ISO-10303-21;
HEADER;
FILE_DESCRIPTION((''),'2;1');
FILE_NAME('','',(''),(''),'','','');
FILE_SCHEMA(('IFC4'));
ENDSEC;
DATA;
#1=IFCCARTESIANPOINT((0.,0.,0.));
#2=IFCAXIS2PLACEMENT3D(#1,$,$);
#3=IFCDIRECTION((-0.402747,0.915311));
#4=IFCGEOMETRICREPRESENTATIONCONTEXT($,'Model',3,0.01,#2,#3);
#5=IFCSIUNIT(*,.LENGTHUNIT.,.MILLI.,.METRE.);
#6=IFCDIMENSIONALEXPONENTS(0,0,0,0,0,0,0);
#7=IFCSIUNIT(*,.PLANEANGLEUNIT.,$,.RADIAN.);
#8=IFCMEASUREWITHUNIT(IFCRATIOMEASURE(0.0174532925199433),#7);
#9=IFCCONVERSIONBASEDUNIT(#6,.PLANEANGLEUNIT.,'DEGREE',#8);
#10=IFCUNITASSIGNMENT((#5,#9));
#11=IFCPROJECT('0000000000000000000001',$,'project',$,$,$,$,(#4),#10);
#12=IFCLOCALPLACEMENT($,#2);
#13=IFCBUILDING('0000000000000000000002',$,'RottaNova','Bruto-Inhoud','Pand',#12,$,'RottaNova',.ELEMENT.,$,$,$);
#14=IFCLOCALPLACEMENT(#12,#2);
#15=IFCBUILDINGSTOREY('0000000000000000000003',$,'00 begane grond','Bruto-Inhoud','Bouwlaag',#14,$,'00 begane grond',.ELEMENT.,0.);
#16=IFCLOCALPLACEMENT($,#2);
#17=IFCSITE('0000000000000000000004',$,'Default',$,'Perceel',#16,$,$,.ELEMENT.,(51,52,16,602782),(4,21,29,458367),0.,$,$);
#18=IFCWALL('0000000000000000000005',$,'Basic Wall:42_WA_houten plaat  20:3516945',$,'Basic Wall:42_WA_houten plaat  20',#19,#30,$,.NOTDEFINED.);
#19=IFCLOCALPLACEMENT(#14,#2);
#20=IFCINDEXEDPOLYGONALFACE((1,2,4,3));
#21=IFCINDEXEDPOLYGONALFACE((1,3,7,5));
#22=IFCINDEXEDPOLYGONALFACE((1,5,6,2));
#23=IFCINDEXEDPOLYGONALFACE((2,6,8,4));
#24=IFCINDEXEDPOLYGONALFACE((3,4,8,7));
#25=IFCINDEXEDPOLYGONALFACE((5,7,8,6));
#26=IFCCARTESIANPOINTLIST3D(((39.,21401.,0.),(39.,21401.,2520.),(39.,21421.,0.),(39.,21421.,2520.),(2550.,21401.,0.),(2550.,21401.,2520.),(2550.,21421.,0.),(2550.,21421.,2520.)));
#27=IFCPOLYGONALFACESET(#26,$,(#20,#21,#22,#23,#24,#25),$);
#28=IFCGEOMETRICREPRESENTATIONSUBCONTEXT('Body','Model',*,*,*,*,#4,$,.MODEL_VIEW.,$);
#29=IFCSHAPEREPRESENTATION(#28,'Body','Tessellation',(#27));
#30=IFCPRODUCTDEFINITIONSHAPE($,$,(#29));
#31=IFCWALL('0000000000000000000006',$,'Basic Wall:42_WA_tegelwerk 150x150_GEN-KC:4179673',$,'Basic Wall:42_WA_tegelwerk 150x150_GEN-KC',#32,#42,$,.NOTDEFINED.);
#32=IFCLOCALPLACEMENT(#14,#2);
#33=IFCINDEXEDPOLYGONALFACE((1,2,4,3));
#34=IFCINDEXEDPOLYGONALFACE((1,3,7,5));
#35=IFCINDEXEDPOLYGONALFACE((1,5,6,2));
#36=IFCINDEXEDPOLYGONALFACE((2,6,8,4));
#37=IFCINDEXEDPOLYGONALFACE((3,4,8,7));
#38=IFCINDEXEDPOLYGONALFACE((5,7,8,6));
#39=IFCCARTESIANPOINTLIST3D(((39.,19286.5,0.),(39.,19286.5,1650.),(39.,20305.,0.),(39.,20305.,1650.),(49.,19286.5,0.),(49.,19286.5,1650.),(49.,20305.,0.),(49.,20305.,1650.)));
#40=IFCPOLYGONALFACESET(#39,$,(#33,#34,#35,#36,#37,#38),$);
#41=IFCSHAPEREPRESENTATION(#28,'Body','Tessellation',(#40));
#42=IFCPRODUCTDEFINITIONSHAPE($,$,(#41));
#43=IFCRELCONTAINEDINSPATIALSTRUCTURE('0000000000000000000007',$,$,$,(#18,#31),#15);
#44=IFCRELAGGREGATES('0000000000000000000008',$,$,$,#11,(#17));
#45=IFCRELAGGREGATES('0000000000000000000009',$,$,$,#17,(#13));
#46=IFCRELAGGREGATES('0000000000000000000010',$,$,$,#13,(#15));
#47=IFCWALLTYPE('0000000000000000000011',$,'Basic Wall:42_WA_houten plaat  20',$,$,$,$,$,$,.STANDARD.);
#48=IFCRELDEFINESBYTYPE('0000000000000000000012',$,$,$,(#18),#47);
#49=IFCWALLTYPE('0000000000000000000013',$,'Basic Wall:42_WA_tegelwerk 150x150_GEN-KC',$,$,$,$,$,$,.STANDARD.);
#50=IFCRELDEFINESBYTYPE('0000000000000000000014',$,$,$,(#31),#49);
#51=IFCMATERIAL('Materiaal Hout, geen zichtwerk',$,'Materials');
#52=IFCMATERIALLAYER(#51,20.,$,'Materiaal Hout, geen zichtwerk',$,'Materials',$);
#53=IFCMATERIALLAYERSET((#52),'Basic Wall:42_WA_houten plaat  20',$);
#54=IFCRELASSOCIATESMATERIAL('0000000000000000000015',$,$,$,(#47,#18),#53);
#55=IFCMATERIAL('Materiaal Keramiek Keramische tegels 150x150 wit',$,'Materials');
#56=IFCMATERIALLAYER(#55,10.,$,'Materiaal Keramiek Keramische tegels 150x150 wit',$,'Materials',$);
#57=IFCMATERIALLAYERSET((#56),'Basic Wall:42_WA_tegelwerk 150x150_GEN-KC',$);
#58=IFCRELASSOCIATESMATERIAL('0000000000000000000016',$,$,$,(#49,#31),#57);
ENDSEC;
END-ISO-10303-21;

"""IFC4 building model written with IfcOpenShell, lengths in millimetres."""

from ifc_helpers import new_model, entity, si_unit, converted_unit, direction, frame, frame_2d, origin, place, context, subcontext, project, spatial, rectangle, extrude, material, layer, layer_set, type_object, element, save


model = new_model("IFC4")

# Units and contexts
model_context = context("Model", 3, precision=0.01, world=origin(), true_north=direction((-0.402747, 0.915311)))
body_context = subcontext(model_context, "Body", "Model", "MODEL_VIEW")
ifc_project = project(units=[si_unit("LENGTHUNIT", "METRE", prefix="MILLI"), converted_unit("PLANEANGLEUNIT", "DEGREE", entity("IfcRatioMeasure", 0.0174532925199433), si_unit("PLANEANGLEUNIT", "RADIAN"), dimensions=[0, 0, 0, 0, 0, 0, 0])], contexts=[model_context])

# Site, building, storey
site_placement = place(None, origin())
site = spatial("IfcSite", under=ifc_project, at=site_placement, Name="Default", ObjectType="Perceel", CompositionType="ELEMENT", RefLatitude=(51, 52, 16, 602782), RefLongitude=(4, 21, 29, 458367), RefElevation=0.0)
building_placement = place(None, origin())
building = spatial("IfcBuilding", under=site, at=building_placement, Name="RottaNova", Description="Bruto-Inhoud", ObjectType="Pand", LongName="RottaNova", CompositionType="ELEMENT")
storey_placement = place(building_placement, origin())
storey = spatial("IfcBuildingStorey", under=building, at=storey_placement, Name="00 begane grond", Description="Bruto-Inhoud", ObjectType="Bouwlaag", LongName="00 begane grond", CompositionType="ELEMENT", Elevation=0.0)

# Walls
ifc_material_1 = material(Name="Materiaal Hout, geen zichtwerk", Category="Materials")
ifc_layer_1 = layer(ifc_material_1, 20.0, Name="Materiaal Hout, geen zichtwerk", Category="Materials")
ifc_layer_set_1 = layer_set([ifc_layer_1], Name="Basic Wall:42_WA_houten plaat  20")
wall_type_1 = type_object("IfcWallType", Name="Basic Wall:42_WA_houten plaat  20", PredefinedType="STANDARD", material=ifc_layer_set_1)
wall_1_placement = place(storey_placement, frame((39.0, 21411.0, 0.0)))
element("IfcWall", 1, at=wall_1_placement, inside=storey, type_object=wall_type_1, material=ifc_layer_set_1, Name="Basic Wall:42_WA_houten plaat  20:3516945", ObjectType="Basic Wall:42_WA_houten plaat  20", PredefinedType="NOTDEFINED", context=body_context, shape_type="SweptSolid", body=[
    extrude(rectangle(XDim=2511.0, YDim=20.0, at=frame_2d((1255.5, 0.0), x_axis=(-1.0, 0.0))), origin(), (0.0, 0.0, 1.0), 2520.0),
])
ifc_material_2 = material(Name="Materiaal Keramiek Keramische tegels 150x150 wit", Category="Materials")
ifc_layer_2 = layer(ifc_material_2, 10.0, Name="Materiaal Keramiek Keramische tegels 150x150 wit", Category="Materials")
ifc_layer_set_2 = layer_set([ifc_layer_2], Name="Basic Wall:42_WA_tegelwerk 150x150_GEN-KC")
wall_type_2 = type_object("IfcWallType", Name="Basic Wall:42_WA_tegelwerk 150x150_GEN-KC", PredefinedType="STANDARD", material=ifc_layer_set_2)
wall_2_placement = place(storey_placement, frame((44.0, 20305.0, 0.0), z_axis=(0.0, 0.0, 1.0), x_axis=(0.0, -1.0, 0.0)))
element("IfcWall", 2, at=wall_2_placement, inside=storey, type_object=wall_type_2, material=ifc_layer_set_2, Name="Basic Wall:42_WA_tegelwerk 150x150_GEN-KC:4179673", ObjectType="Basic Wall:42_WA_tegelwerk 150x150_GEN-KC", PredefinedType="NOTDEFINED", context=body_context, shape_type="SweptSolid", body=[
    extrude(rectangle(XDim=1018.5, YDim=10.0, at=frame_2d((509.2, 0.0), x_axis=(-1.0, 0.0))), origin(), (0.0, 0.0, 1.0), 1650.0),
])

save(model, "model.ifc")
